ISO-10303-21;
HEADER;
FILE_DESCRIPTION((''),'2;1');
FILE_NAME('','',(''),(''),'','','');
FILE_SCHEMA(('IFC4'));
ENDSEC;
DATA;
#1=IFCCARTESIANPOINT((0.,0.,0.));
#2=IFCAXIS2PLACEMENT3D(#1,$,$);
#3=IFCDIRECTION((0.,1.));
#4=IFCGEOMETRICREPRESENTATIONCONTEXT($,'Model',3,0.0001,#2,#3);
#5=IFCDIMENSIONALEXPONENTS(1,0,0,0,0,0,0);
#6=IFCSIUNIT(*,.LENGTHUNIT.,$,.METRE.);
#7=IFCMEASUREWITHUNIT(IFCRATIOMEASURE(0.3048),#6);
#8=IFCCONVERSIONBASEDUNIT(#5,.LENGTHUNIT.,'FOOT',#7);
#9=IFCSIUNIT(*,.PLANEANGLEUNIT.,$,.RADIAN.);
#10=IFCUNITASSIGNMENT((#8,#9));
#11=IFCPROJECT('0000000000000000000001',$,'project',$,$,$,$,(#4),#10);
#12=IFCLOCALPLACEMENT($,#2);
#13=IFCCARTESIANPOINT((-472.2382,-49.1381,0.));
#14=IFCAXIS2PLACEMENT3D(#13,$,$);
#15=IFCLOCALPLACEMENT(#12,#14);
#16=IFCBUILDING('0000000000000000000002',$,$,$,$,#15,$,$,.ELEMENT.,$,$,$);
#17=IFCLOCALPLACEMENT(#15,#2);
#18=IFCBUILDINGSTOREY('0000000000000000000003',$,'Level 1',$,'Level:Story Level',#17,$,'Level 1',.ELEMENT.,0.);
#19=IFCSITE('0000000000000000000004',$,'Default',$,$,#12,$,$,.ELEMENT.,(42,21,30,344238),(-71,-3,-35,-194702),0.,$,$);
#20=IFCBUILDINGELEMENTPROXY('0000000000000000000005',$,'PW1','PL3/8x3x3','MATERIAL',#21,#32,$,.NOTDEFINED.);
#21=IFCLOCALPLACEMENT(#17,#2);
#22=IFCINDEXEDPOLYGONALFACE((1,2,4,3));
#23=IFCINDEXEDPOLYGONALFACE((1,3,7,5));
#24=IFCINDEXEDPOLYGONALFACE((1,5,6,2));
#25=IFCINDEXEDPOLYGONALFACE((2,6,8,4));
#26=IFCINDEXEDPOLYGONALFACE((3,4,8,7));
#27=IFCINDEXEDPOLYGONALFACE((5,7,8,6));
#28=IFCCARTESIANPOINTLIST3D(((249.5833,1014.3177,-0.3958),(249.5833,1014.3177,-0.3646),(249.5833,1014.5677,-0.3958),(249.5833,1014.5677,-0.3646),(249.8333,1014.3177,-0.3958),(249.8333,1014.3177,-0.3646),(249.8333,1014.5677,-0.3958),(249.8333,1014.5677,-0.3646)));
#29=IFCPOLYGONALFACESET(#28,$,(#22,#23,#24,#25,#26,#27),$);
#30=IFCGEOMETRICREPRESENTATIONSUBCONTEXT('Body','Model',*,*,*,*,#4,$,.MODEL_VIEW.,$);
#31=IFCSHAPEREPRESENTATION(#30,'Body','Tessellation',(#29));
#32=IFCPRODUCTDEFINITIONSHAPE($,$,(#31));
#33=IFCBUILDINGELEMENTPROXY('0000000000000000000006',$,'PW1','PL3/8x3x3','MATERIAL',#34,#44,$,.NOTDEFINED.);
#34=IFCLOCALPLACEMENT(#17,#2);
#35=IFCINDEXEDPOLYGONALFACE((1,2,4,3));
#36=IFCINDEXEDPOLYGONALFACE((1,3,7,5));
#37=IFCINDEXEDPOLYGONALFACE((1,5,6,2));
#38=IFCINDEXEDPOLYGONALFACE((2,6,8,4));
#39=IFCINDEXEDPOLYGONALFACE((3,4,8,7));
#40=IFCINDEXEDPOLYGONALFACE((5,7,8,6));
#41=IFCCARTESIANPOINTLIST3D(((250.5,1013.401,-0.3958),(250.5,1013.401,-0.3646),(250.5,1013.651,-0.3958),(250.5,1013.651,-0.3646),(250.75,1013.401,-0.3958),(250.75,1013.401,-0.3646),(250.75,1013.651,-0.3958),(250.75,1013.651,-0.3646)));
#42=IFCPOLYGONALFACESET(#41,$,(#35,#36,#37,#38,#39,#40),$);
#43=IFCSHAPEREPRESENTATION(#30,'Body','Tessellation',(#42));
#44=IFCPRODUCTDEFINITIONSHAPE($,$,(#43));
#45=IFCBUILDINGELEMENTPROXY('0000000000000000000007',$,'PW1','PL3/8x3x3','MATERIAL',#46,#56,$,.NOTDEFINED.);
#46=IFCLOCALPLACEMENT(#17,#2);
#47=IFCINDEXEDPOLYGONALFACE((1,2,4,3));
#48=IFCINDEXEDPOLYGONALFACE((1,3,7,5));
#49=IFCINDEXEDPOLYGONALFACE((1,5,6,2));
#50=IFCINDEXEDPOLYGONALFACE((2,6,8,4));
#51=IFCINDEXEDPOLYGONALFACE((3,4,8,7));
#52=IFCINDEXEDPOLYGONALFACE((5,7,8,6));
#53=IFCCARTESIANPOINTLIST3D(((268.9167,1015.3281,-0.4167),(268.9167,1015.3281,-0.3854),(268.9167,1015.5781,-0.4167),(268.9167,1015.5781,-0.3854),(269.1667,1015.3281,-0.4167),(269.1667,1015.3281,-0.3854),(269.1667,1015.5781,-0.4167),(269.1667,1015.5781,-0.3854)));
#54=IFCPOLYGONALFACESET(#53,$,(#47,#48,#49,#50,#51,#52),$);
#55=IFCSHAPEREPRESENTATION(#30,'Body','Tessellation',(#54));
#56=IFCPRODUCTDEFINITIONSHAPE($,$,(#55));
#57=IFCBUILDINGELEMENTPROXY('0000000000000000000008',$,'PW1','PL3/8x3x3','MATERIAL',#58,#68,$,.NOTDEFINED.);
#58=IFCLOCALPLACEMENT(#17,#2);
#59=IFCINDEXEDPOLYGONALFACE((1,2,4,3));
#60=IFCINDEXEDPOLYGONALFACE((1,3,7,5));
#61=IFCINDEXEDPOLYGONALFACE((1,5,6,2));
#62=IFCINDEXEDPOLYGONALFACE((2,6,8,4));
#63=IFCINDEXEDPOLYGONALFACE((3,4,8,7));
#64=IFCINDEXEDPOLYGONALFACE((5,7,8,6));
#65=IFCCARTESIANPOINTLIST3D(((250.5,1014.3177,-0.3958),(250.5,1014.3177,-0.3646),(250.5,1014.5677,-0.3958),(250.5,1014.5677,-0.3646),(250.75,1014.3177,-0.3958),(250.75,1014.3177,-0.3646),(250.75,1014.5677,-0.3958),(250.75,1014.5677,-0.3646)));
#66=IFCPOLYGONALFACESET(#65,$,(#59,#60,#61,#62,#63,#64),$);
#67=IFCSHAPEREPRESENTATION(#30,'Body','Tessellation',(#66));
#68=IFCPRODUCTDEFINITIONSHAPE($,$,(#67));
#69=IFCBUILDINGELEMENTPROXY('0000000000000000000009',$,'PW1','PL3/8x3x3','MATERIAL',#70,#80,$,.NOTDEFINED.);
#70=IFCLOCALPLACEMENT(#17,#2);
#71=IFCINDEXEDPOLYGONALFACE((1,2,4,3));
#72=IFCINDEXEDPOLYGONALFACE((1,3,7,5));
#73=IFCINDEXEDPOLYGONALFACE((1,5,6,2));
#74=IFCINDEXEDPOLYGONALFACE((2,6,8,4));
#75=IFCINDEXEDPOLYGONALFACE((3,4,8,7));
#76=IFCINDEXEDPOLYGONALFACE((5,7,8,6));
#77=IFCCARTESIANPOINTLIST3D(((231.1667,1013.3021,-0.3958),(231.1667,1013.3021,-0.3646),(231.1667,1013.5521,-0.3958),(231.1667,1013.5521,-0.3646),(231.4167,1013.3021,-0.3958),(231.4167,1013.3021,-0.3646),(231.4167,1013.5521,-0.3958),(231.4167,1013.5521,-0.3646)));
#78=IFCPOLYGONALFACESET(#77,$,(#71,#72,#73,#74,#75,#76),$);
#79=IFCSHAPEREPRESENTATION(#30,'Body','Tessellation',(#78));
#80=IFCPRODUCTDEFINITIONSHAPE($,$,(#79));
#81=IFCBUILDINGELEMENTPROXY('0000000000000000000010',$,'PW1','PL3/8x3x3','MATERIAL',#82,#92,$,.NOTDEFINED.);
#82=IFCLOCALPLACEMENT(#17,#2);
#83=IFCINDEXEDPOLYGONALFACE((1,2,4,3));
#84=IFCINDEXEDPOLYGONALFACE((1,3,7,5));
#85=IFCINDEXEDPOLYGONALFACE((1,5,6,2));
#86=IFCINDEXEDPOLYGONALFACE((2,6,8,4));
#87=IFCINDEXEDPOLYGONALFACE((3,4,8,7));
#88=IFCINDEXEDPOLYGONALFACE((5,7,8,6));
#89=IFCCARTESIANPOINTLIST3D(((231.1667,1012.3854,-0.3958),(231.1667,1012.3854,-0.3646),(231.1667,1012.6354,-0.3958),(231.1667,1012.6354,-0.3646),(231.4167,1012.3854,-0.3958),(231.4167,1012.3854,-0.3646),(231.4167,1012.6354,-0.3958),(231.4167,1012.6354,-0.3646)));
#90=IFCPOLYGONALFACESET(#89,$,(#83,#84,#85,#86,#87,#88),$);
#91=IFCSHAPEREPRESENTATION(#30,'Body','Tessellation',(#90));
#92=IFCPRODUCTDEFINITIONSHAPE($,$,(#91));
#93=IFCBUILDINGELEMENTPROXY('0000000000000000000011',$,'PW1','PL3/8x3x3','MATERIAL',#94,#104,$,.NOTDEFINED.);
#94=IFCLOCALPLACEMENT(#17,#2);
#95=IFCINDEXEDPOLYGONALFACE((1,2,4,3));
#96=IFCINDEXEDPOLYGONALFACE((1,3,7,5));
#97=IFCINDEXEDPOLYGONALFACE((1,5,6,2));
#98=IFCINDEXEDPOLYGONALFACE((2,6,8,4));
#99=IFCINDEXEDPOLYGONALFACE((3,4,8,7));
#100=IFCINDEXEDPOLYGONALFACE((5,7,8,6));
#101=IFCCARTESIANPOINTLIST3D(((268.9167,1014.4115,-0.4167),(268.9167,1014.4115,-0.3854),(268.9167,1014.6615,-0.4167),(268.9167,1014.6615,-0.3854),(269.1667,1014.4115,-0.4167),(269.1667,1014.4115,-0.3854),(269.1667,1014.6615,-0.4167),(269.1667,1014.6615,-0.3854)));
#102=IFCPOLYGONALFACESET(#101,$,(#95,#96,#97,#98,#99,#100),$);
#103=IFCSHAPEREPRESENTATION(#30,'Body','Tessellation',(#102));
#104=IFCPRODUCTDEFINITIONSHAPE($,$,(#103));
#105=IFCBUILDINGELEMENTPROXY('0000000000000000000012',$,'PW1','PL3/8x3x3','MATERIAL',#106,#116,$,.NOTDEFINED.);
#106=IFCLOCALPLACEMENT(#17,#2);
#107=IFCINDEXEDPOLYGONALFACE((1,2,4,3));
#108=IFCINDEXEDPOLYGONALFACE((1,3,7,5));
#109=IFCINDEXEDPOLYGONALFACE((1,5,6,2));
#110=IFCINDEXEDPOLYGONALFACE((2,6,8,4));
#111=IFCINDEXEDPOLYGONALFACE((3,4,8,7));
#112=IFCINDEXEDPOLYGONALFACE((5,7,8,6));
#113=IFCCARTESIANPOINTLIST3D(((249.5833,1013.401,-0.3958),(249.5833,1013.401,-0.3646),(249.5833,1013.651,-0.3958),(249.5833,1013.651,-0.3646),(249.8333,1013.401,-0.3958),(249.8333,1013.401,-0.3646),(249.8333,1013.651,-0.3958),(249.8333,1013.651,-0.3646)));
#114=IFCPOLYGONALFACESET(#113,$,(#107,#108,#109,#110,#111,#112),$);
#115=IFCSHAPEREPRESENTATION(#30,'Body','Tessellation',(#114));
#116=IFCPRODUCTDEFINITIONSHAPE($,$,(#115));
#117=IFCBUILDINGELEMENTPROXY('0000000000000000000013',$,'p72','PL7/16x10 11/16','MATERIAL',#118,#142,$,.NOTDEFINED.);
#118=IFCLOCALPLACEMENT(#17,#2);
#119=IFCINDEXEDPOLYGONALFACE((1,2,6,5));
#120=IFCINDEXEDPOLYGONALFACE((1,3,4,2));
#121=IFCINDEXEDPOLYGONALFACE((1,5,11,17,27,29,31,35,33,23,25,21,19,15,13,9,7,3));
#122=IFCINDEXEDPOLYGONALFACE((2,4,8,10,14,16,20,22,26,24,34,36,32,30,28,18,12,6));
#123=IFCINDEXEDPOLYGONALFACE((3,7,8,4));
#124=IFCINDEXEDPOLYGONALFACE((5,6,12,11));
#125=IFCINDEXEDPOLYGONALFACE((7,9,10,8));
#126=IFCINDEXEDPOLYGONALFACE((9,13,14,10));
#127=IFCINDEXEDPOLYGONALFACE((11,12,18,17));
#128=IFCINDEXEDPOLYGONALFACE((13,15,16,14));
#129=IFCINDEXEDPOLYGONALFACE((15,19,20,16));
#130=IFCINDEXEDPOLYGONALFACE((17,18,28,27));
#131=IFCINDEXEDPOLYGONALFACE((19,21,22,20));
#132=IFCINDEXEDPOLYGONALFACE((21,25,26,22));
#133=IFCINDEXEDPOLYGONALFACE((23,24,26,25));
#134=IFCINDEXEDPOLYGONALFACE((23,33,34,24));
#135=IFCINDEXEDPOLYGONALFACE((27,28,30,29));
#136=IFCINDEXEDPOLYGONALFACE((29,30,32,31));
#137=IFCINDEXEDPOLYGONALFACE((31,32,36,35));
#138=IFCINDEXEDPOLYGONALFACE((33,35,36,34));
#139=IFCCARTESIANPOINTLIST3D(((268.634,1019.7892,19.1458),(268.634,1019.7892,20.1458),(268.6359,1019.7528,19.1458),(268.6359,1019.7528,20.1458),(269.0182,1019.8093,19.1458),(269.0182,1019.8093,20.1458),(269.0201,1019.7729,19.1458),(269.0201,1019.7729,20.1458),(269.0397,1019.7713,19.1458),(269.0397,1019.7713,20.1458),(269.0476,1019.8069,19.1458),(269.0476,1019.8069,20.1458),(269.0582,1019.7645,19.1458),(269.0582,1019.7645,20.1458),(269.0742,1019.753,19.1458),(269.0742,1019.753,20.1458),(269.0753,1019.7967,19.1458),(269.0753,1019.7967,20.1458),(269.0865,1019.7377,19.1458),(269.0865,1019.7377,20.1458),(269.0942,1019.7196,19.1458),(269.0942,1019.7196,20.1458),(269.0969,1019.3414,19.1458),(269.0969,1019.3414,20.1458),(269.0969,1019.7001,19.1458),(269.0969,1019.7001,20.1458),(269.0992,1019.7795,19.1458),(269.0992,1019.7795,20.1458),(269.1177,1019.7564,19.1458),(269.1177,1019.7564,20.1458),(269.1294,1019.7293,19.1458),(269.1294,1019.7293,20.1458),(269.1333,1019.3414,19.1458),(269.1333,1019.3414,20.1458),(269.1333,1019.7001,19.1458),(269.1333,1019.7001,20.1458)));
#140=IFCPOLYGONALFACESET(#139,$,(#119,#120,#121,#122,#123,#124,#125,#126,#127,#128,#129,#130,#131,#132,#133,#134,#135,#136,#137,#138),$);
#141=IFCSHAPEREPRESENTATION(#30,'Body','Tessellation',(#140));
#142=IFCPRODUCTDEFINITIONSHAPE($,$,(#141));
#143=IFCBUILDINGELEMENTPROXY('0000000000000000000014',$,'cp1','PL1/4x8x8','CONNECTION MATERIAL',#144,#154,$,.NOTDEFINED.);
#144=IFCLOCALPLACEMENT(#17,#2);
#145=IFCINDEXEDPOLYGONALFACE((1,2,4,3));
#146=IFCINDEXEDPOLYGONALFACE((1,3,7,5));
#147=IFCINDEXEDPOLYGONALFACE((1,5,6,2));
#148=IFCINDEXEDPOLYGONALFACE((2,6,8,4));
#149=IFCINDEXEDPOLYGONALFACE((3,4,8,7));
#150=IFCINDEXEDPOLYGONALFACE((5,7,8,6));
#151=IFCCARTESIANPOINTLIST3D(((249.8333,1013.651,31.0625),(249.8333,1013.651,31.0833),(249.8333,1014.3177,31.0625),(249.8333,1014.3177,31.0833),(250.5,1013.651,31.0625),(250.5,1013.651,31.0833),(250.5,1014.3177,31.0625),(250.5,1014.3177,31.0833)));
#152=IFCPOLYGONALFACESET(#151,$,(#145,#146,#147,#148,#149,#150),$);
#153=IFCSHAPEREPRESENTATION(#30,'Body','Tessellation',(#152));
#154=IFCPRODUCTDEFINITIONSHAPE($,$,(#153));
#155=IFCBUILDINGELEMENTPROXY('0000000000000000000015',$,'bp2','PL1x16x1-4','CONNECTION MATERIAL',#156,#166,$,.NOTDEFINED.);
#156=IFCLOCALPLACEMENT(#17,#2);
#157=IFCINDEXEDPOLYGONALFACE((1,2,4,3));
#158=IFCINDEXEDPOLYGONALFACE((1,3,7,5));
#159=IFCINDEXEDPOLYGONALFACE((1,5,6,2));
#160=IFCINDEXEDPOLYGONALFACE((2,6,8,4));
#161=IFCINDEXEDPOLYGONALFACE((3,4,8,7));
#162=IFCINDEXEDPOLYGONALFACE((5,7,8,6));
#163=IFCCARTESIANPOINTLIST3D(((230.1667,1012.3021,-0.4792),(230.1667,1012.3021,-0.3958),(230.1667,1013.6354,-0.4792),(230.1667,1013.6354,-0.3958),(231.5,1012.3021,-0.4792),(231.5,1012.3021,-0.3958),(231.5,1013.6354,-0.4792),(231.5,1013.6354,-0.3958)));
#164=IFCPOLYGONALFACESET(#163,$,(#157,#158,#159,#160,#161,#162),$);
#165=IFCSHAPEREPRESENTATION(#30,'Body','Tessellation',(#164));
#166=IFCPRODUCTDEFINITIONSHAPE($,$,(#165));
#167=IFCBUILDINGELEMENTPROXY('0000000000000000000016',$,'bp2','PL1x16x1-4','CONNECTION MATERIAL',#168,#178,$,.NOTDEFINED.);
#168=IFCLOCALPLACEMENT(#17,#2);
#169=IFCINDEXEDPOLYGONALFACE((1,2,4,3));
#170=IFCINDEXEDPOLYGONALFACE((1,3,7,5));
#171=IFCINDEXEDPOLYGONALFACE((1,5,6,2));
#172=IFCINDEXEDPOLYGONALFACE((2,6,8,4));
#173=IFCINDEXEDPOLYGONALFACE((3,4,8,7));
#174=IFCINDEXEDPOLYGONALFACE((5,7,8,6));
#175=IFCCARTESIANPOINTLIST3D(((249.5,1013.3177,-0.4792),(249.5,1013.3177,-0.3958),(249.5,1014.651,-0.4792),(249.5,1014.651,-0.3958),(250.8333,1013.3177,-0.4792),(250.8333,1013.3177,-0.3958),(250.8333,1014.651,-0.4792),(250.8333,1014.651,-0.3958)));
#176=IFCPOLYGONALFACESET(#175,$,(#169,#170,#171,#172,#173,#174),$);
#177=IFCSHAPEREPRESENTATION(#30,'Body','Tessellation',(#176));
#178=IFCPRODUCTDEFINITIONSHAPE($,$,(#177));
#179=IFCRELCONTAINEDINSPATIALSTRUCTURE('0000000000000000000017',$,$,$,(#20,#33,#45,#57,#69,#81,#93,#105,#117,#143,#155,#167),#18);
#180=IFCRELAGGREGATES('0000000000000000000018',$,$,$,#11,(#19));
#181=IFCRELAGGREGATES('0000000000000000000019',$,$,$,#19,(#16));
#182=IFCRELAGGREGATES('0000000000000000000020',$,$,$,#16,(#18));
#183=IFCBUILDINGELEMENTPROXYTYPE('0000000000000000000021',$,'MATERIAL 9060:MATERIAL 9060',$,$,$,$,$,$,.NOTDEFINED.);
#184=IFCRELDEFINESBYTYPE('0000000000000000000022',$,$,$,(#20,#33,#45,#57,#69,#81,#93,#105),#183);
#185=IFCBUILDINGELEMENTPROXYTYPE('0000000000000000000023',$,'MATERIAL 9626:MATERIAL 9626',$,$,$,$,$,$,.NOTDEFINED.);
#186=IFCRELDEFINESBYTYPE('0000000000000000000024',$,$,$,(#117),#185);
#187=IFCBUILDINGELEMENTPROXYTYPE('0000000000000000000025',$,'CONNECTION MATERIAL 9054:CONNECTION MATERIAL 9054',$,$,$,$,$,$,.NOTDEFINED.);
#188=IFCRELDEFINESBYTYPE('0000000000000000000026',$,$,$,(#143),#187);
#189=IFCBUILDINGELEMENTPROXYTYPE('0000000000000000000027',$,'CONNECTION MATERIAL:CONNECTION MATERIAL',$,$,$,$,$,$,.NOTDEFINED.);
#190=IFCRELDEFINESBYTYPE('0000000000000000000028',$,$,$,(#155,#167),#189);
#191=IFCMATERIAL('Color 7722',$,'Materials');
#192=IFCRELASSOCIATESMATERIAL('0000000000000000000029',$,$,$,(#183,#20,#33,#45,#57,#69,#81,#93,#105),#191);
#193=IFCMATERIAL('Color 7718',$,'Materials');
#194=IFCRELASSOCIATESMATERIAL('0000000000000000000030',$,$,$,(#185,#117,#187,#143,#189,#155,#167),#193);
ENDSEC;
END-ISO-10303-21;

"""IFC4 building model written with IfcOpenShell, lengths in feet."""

from ifc_helpers import new_model, entity, si_unit, converted_unit, direction, frame, origin, origin_2d_with_axis, place, context, subcontext, project, spatial, polyline, rectangle, outline, extrude, source, transform, mapped, material, type_object, type_shapes, element, save


model = new_model("IFC4")

# Units and contexts
model_context = context("Model", 3, precision=0.0001, world=origin(), true_north=direction((0.0, 1.0)))
body_context = subcontext(model_context, "Body", "Model", "MODEL_VIEW")
ifc_project = project(units=[converted_unit("LENGTHUNIT", "FOOT", entity("IfcRatioMeasure", 0.3048), si_unit("LENGTHUNIT", "METRE"), dimensions=[1, 0, 0, 0, 0, 0, 0]), si_unit("PLANEANGLEUNIT", "RADIAN")], contexts=[model_context])

# Site, building, storey
site_placement = place(None, origin())
site = spatial("IfcSite", under=ifc_project, at=site_placement, Name="Default", CompositionType="ELEMENT", RefLatitude=(42, 21, 30, 344238), RefLongitude=(-71, -3, -35, -194702), RefElevation=0.0)
building_placement = place(site_placement, frame((-472.2382, -49.1381, 0.0)))
building = spatial("IfcBuilding", under=site, at=building_placement, CompositionType="ELEMENT")
storey_placement = place(building_placement, origin())
storey = spatial("IfcBuildingStorey", under=building, at=storey_placement, Name="Level 1", ObjectType="Level:Story Level", LongName="Level 1", CompositionType="ELEMENT", Elevation=0.0)

# Building element proxies
ifc_material_1 = material(Name="Color 7722", Category="Materials")
building_element_proxy_type_1 = type_object("IfcBuildingElementProxyType", Name="MATERIAL 9060:MATERIAL 9060", PredefinedType="NOTDEFINED", material=ifc_material_1)
shared_shape_1 = source(origin(), body_context, "Body", "SweptSolid", [
    extrude(rectangle(XDim=0.25, YDim=0.25, at=origin_2d_with_axis()), frame((0.125, -0.125, 0.0)), (0.0, 0.0, 1.0), 0.0312),
])
type_shapes(building_element_proxy_type_1, [shared_shape_1])
for number, where, z_axis, x_axis, name in (
    (1, (249.5833, 1014.5677, -0.3646), (0.0, 0.0, -1.0), (0.0, -1.0, 0.0), "PW1"),
    (2, (250.5, 1013.651, -0.3646), (0.0, 0.0, -1.0), (0.0, -1.0, 0.0), "PW1"),
    (3, (268.9167, 1015.5781, -0.3854), (0.0, 0.0, -1.0), (0.0, -1.0, 0.0), "PW1"),
    (4, (250.5, 1014.5677, -0.3646), (0.0, 0.0, -1.0), (0.0, -1.0, 0.0), "PW1"),
    (5, (231.1667, 1013.5521, -0.3646), (0.0, 0.0, -1.0), (0.0, -1.0, 0.0), "PW1"),
    (6, (231.1667, 1012.6354, -0.3646), (0.0, 0.0, -1.0), (0.0, -1.0, 0.0), "PW1"),
    (7, (268.9167, 1014.6615, -0.3854), (0.0, 0.0, -1.0), (0.0, -1.0, 0.0), "PW1"),
    (8, (249.5833, 1013.651, -0.3646), (0.0, 0.0, -1.0), (0.0, -1.0, 0.0), "PW1"),
):
    element("IfcBuildingElementProxy", number, at=place(building_placement, frame(where, z_axis=z_axis, x_axis=x_axis)), inside=storey, type_object=building_element_proxy_type_1, material=ifc_material_1, Name=name, Description="PL3/8x3x3", ObjectType="MATERIAL", PredefinedType="NOTDEFINED", context=body_context, shape_type="MappedRepresentation", body=[
        mapped(shared_shape_1, transform((0.0, 0.0, 0.0), scale=1.0)),
    ])
ifc_material_2 = material(Name="Color 7718", Category="Materials")
building_element_proxy_type_2 = type_object("IfcBuildingElementProxyType", Name="MATERIAL 9626:MATERIAL 9626", PredefinedType="NOTDEFINED", material=ifc_material_2)
shared_shape_2 = source(origin(), body_context, "Body", "SweptSolid", [
    extrude(outline(polyline([(0.0122, -0.1005), (0.3709, -0.1005), (0.3709, -0.0641), (0.0122, -0.0641), (-0.0073, -0.0614), (-0.0253, -0.0536), (-0.0407, -0.0413), (-0.0522, -0.0254), (-0.059, -0.0069), (-0.0606, 0.0127), (-0.0404, 0.3969), (-0.0769, 0.3988), (-0.097, 0.0146), (-0.0946, -0.0148), (-0.0843, -0.0425), (-0.0671, -0.0664), (-0.0441, -0.0849), (-0.017, -0.0965), (0.0122, -0.1005)])), frame((0.0, 0.3709, 0.3988), z_axis=(1.0, 0.0, 0.0), x_axis=(0.0, -1.0, 0.0)), (0.0, 0.0, 1.0), 1.0),
])
type_shapes(building_element_proxy_type_2, [shared_shape_2])
proxy_1_placement = place(building_placement, frame((268.634, 1019.3414, 20.1458), z_axis=(1.0, 0.0, 0.0), x_axis=(0.0, 0.0, -1.0)))
element("IfcBuildingElementProxy", 9, at=proxy_1_placement, inside=storey, type_object=building_element_proxy_type_2, material=ifc_material_2, Name="p72", Description="PL7/16x10 11/16", ObjectType="MATERIAL", PredefinedType="NOTDEFINED", context=body_context, shape_type="MappedRepresentation", body=[
    mapped(shared_shape_2, transform((0.0, 0.0, 0.0), scale=1.0)),
])
building_element_proxy_type_3 = type_object("IfcBuildingElementProxyType", Name="CONNECTION MATERIAL 9054:CONNECTION MATERIAL 9054", PredefinedType="NOTDEFINED", material=ifc_material_2)
shared_shape_3 = source(origin(), body_context, "Body", "SweptSolid", [
    extrude(rectangle(XDim=0.6667, YDim=0.6667, at=origin_2d_with_axis()), frame((0.0, 0.0, -0.0208)), (0.0, 0.0, 1.0), 0.0208),
])
type_shapes(building_element_proxy_type_3, [shared_shape_3])
proxy_2_placement = place(building_placement, frame((250.1667, 1013.9844, 31.0625), z_axis=(0.0, 0.0, -1.0), x_axis=(1.0, 0.0, 0.0)))
element("IfcBuildingElementProxy", 10, at=proxy_2_placement, inside=storey, type_object=building_element_proxy_type_3, material=ifc_material_2, Name="cp1", Description="PL1/4x8x8", ObjectType="CONNECTION MATERIAL", PredefinedType="NOTDEFINED", context=body_context, shape_type="MappedRepresentation", body=[
    mapped(shared_shape_3, transform((0.0, 0.0, 0.0), scale=1.0)),
])
building_element_proxy_type_4 = type_object("IfcBuildingElementProxyType", Name="CONNECTION MATERIAL:CONNECTION MATERIAL", PredefinedType="NOTDEFINED", material=ifc_material_2)
shared_shape_4 = source(origin(), body_context, "Body", "SweptSolid", [
    extrude(rectangle(XDim=1.3333, YDim=1.3333, at=origin_2d_with_axis()), frame((0.0, 0.0, -0.0833)), (0.0, 0.0, 1.0), 0.0833),
])
type_shapes(building_element_proxy_type_4, [shared_shape_4])
for number, where, name in (
    (11, (230.8333, 1012.9688, -0.3958), "bp2"),
    (12, (250.1667, 1013.9844, -0.3958), "bp2"),
):
    element("IfcBuildingElementProxy", number, at=place(building_placement, frame(where)), inside=storey, type_object=building_element_proxy_type_4, material=ifc_material_2, Name=name, Description="PL1x16x1-4", ObjectType="CONNECTION MATERIAL", PredefinedType="NOTDEFINED", context=body_context, shape_type="MappedRepresentation", body=[
        mapped(shared_shape_4, transform((0.0, 0.0, 0.0), scale=1.0)),
    ])

save(model, "model.ifc")
